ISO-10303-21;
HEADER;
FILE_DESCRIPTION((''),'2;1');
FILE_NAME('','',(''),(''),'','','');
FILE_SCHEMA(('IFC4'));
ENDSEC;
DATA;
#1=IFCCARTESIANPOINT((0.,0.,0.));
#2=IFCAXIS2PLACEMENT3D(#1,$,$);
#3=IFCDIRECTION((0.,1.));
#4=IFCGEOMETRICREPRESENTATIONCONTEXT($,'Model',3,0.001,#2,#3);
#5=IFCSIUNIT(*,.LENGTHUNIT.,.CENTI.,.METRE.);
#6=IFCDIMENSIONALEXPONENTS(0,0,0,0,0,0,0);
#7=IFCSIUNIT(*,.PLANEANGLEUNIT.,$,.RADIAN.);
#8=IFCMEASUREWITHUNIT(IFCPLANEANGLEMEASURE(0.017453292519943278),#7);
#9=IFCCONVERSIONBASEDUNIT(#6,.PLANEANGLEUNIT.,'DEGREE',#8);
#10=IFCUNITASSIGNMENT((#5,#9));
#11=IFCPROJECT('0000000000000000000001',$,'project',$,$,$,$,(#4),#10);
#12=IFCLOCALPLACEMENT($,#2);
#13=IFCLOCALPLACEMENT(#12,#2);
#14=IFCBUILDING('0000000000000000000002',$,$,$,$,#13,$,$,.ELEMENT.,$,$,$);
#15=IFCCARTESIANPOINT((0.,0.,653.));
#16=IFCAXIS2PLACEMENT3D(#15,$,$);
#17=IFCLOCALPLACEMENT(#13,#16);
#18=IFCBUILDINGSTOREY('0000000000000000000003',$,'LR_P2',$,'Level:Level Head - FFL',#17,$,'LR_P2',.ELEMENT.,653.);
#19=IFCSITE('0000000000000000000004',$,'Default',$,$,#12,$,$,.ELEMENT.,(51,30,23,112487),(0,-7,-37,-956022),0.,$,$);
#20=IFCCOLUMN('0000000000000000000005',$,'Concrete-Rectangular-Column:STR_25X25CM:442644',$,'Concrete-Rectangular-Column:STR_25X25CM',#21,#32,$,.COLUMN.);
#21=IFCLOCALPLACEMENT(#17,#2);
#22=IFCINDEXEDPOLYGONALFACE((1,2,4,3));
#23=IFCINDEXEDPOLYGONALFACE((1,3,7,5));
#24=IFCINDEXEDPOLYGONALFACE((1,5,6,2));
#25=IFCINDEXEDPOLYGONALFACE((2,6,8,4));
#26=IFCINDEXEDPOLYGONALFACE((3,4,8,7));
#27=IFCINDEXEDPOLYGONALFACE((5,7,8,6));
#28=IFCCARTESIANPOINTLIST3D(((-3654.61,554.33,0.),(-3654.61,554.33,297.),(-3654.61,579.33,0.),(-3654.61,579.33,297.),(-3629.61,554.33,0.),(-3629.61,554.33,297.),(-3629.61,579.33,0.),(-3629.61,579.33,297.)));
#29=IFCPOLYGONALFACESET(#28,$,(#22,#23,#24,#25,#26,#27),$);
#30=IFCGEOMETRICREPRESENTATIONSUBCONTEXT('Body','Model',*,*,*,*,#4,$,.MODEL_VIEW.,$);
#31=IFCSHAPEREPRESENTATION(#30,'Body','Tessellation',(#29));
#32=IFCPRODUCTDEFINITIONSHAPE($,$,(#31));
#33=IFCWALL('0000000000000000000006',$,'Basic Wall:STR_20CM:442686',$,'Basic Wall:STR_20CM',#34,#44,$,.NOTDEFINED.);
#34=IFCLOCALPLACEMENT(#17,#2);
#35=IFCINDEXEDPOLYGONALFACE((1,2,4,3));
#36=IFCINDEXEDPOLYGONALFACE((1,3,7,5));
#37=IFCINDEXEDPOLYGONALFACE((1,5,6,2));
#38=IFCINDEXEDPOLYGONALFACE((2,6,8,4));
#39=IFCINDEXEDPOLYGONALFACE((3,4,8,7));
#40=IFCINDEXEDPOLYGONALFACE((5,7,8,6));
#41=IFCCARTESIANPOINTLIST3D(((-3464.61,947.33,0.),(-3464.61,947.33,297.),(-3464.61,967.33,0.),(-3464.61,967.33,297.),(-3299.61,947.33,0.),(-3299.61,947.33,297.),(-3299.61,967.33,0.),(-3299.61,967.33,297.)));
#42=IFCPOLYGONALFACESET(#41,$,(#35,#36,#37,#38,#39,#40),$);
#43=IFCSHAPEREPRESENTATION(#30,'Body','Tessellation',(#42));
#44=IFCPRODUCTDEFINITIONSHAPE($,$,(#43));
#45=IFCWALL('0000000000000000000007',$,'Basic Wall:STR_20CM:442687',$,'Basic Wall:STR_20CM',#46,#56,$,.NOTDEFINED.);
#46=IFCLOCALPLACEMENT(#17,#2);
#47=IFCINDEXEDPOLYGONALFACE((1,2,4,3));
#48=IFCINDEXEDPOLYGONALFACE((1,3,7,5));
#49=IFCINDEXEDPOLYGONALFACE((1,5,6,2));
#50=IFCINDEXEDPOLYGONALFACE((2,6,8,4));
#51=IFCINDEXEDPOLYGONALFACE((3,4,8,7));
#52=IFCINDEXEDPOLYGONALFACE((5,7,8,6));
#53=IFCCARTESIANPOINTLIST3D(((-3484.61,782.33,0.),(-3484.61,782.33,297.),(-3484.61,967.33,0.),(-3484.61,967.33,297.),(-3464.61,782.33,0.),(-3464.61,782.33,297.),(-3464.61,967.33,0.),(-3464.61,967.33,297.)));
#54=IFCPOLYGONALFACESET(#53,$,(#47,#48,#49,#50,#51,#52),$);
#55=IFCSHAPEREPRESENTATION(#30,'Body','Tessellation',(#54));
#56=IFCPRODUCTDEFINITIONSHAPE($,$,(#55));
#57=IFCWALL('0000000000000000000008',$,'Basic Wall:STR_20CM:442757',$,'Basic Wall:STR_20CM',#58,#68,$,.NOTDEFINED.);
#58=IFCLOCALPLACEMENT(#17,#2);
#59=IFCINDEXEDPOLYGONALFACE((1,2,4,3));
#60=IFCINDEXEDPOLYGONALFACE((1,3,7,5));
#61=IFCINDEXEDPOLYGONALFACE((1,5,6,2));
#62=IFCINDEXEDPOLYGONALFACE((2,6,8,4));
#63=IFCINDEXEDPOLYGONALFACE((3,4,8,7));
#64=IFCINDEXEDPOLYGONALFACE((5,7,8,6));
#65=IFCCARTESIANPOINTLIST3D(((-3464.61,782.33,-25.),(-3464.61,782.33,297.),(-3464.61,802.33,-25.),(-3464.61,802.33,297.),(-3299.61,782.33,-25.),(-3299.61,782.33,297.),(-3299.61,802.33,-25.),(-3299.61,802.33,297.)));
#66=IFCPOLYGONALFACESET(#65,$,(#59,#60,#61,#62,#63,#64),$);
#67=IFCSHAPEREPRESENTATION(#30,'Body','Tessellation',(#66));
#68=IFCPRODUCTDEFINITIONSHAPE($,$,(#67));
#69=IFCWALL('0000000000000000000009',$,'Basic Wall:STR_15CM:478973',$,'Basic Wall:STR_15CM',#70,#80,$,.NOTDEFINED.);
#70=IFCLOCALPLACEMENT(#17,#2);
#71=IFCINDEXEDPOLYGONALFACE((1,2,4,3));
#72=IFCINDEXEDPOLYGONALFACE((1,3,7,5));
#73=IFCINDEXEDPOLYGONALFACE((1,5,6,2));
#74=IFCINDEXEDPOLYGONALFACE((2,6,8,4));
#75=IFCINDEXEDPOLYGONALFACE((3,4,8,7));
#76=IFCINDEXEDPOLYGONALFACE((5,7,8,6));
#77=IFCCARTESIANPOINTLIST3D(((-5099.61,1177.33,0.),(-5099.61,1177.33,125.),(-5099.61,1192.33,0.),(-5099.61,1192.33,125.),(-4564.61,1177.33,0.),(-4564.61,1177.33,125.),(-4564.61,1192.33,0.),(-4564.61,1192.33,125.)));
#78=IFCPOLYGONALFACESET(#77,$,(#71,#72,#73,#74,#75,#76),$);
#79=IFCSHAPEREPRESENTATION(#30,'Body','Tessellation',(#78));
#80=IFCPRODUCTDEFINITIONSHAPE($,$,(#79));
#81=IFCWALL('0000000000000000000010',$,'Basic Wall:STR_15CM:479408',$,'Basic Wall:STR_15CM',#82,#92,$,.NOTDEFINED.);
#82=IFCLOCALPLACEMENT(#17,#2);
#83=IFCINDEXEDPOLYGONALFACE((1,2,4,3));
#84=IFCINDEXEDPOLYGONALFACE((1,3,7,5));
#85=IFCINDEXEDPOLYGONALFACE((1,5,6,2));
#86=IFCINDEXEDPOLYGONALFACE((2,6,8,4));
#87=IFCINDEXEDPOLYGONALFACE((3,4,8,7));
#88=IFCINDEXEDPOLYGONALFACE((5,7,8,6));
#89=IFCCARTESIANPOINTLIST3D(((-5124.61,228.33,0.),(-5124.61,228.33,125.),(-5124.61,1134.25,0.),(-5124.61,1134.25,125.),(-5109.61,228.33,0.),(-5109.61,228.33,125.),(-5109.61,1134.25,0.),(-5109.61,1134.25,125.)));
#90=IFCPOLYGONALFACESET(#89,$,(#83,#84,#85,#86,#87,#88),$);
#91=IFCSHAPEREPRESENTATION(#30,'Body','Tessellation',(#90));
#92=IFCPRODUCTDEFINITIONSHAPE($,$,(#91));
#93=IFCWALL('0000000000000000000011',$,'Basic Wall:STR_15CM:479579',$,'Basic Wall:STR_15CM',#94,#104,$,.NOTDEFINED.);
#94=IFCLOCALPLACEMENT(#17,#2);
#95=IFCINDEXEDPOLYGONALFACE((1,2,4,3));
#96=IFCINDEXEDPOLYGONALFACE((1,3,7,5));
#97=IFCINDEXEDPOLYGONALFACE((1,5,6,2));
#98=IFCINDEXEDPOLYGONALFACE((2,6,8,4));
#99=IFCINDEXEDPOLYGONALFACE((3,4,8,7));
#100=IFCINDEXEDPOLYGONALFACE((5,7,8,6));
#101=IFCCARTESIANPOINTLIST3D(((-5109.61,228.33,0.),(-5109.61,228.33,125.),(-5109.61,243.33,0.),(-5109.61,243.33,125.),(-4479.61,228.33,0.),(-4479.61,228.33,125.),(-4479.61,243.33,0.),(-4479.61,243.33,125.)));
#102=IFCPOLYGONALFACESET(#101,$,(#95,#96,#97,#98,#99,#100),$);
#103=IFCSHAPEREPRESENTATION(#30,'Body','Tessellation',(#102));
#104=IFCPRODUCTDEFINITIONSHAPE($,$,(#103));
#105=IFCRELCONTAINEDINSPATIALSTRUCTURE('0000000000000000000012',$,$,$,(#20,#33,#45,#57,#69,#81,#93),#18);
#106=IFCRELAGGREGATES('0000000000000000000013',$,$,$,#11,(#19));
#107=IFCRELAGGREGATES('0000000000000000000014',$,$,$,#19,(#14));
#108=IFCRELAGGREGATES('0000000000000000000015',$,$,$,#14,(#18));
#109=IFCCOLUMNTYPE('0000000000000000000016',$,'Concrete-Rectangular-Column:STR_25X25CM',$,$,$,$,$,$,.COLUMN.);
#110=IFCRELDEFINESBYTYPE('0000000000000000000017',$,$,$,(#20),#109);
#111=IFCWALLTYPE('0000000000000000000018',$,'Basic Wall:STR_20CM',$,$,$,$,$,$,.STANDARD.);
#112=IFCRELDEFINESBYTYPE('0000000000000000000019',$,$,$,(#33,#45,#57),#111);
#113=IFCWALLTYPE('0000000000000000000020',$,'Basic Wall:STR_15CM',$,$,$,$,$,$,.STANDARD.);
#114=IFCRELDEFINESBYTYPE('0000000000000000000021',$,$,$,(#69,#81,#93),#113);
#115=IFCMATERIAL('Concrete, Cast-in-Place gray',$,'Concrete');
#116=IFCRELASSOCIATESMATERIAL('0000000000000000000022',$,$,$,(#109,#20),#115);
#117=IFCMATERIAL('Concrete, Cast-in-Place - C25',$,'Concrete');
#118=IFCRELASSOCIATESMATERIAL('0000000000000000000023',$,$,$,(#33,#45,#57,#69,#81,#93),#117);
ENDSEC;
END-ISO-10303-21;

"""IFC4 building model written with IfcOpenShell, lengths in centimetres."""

from ifc_helpers import new_model, entity, si_unit, converted_unit, direction, frame, origin, place, context, subcontext, project, spatial, indexed_curve, outline, extrude, source, transform, mapped, material, type_object, type_shapes, element, save


model = new_model("IFC4")

# Units and contexts
model_context = context("Model", 3, precision=0.001, world=origin(), true_north=direction((0.0, 1.0)))
body_context = subcontext(model_context, "Body", "Model", "MODEL_VIEW")
ifc_project = project(units=[si_unit("LENGTHUNIT", "METRE", prefix="CENTI"), converted_unit("PLANEANGLEUNIT", "DEGREE", entity("IfcPlaneAngleMeasure", 0.017453292519943278), si_unit("PLANEANGLEUNIT", "RADIAN"), dimensions=[0, 0, 0, 0, 0, 0, 0])], contexts=[model_context])

# Site, building, storey
site_placement = place(None, origin())
site = spatial("IfcSite", under=ifc_project, at=site_placement, Name="Default", CompositionType="ELEMENT", RefLatitude=(51, 30, 23, 112487), RefLongitude=(0, -7, -37, -956022), RefElevation=0.0)
building_placement = place(site_placement, origin())
building = spatial("IfcBuilding", under=site, at=building_placement, CompositionType="ELEMENT")
storey_placement = place(building_placement, frame((0.0, 0.0, 653.0)))
storey = spatial("IfcBuildingStorey", under=building, at=storey_placement, Name="LR_P2", ObjectType="Level:Level Head - FFL", LongName="LR_P2", CompositionType="ELEMENT", Elevation=653.0)

# Column
ifc_material_1 = material(Name="Concrete, Cast-in-Place gray", Category="Concrete")
column_type_1 = type_object("IfcColumnType", Name="Concrete-Rectangular-Column:STR_25X25CM", PredefinedType="COLUMN", material=ifc_material_1)
shared_shape_1 = source(origin(), body_context, "Body", "SweptSolid", [
    extrude(outline(indexed_curve([(-12.5, -12.5), (12.5, -12.5), (12.5, 12.5), (-12.5, 12.5), (-12.5, -12.5)], self_intersect=False)), frame((-3642.11, 566.83, 653.0), z_axis=(0.0, 0.0, 1.0), x_axis=(-1.0, 0.0, 0.0)), (0.0, 0.0, 1.0), 297.0),
])
type_shapes(column_type_1, [shared_shape_1])
column_1_placement = place(storey_placement, frame((0.0, 0.0, -653.0)))
element("IfcColumn", 1, at=column_1_placement, inside=storey, type_object=column_type_1, material=ifc_material_1, Name="Concrete-Rectangular-Column:STR_25X25CM:442644", ObjectType="Concrete-Rectangular-Column:STR_25X25CM", PredefinedType="COLUMN", context=body_context, shape_type="MappedRepresentation", body=[
    mapped(shared_shape_1, transform((0.0, 0.0, 0.0), scale=1.0)),
])

# Walls
ifc_material_2 = material(Name="Concrete, Cast-in-Place - C25", Category="Concrete")
wall_type_1 = type_object("IfcWallType", Name="Basic Wall:STR_20CM", PredefinedType="STANDARD")
wall_1_placement = place(storey_placement, frame((-3464.61, 957.33, 0.0)))
element("IfcWall", 2, at=wall_1_placement, inside=storey, type_object=wall_type_1, material=ifc_material_2, Name="Basic Wall:STR_20CM:442686", ObjectType="Basic Wall:STR_20CM", PredefinedType="NOTDEFINED", context=body_context, shape_type="SweptSolid", body=[
    extrude(outline(indexed_curve([(165.0, 10.0), (0.0, 10.0), (0.0, -10.0), (165.0, -10.0), (165.0, 10.0)], self_intersect=False)), origin(), (0.0, 0.0, 1.0), 297.0),
])
wall_2_placement = place(storey_placement, frame((-3474.61, 782.33, 0.0), z_axis=(0.0, 0.0, 1.0), x_axis=(0.0, 1.0, 0.0)))
element("IfcWall", 3, at=wall_2_placement, inside=storey, type_object=wall_type_1, material=ifc_material_2, Name="Basic Wall:STR_20CM:442687", ObjectType="Basic Wall:STR_20CM", PredefinedType="NOTDEFINED", context=body_context, shape_type="SweptSolid", body=[
    extrude(outline(indexed_curve([(185.0, 10.0), (0.0, 10.0), (0.0, -10.0), (185.0, -10.0), (185.0, 10.0)], self_intersect=False)), origin(), (0.0, 0.0, 1.0), 297.0),
])
wall_3_placement = place(storey_placement, frame((-3299.61, 792.33, -25.0), z_axis=(0.0, 0.0, 1.0), x_axis=(-1.0, 0.0, 0.0)))
element("IfcWall", 4, at=wall_3_placement, inside=storey, type_object=wall_type_1, material=ifc_material_2, Name="Basic Wall:STR_20CM:442757", ObjectType="Basic Wall:STR_20CM", PredefinedType="NOTDEFINED", context=body_context, shape_type="SweptSolid", body=[
    extrude(outline(indexed_curve([(165.0, 10.0), (0.0, 10.0), (0.0, -10.0), (165.0, -10.0), (165.0, 10.0)], self_intersect=False)), origin(), (0.0, 0.0, 1.0), 322.0),
])
wall_type_2 = type_object("IfcWallType", Name="Basic Wall:STR_15CM", PredefinedType="STANDARD")
wall_4_placement = place(storey_placement, frame((-4564.61, 1184.83, 0.0), z_axis=(0.0, 0.0, 1.0), x_axis=(-1.0, 0.0, 0.0)))
element("IfcWall", 5, at=wall_4_placement, inside=storey, type_object=wall_type_2, material=ifc_material_2, Name="Basic Wall:STR_15CM:478973", ObjectType="Basic Wall:STR_15CM", PredefinedType="NOTDEFINED", context=body_context, shape_type="SweptSolid", body=[
    extrude(outline(indexed_curve([(535.0, 7.5), (0.0, 7.5), (0.0, -7.5), (535.0, -7.5), (535.0, 7.5)], self_intersect=False)), origin(), (0.0, 0.0, 1.0), 125.0),
])
wall_5_placement = place(storey_placement, frame((-5117.11, 228.33, 0.0), z_axis=(0.0, 0.0, 1.0), x_axis=(0.0, 1.0, 0.0)))
element("IfcWall", 6, at=wall_5_placement, inside=storey, type_object=wall_type_2, material=ifc_material_2, Name="Basic Wall:STR_15CM:479408", ObjectType="Basic Wall:STR_15CM", PredefinedType="NOTDEFINED", context=body_context, shape_type="SweptSolid", body=[
    extrude(outline(indexed_curve([(905.92, 7.5), (0.0, 7.5), (0.0, -7.5), (905.92, -7.5), (905.92, 7.5)], self_intersect=False)), origin(), (0.0, 0.0, 1.0), 125.0),
])
wall_6_placement = place(storey_placement, frame((-4479.61, 235.83, 0.0), z_axis=(0.0, 0.0, 1.0), x_axis=(-1.0, 0.0, 0.0)))
element("IfcWall", 7, at=wall_6_placement, inside=storey, type_object=wall_type_2, material=ifc_material_2, Name="Basic Wall:STR_15CM:479579", ObjectType="Basic Wall:STR_15CM", PredefinedType="NOTDEFINED", context=body_context, shape_type="SweptSolid", body=[
    extrude(outline(indexed_curve([(630.0, 7.5), (0.0, 7.5), (0.0, -7.5), (630.0, -7.5), (630.0, 7.5)], self_intersect=False)), origin(), (0.0, 0.0, 1.0), 125.0),
])

save(model, "model.ifc")
